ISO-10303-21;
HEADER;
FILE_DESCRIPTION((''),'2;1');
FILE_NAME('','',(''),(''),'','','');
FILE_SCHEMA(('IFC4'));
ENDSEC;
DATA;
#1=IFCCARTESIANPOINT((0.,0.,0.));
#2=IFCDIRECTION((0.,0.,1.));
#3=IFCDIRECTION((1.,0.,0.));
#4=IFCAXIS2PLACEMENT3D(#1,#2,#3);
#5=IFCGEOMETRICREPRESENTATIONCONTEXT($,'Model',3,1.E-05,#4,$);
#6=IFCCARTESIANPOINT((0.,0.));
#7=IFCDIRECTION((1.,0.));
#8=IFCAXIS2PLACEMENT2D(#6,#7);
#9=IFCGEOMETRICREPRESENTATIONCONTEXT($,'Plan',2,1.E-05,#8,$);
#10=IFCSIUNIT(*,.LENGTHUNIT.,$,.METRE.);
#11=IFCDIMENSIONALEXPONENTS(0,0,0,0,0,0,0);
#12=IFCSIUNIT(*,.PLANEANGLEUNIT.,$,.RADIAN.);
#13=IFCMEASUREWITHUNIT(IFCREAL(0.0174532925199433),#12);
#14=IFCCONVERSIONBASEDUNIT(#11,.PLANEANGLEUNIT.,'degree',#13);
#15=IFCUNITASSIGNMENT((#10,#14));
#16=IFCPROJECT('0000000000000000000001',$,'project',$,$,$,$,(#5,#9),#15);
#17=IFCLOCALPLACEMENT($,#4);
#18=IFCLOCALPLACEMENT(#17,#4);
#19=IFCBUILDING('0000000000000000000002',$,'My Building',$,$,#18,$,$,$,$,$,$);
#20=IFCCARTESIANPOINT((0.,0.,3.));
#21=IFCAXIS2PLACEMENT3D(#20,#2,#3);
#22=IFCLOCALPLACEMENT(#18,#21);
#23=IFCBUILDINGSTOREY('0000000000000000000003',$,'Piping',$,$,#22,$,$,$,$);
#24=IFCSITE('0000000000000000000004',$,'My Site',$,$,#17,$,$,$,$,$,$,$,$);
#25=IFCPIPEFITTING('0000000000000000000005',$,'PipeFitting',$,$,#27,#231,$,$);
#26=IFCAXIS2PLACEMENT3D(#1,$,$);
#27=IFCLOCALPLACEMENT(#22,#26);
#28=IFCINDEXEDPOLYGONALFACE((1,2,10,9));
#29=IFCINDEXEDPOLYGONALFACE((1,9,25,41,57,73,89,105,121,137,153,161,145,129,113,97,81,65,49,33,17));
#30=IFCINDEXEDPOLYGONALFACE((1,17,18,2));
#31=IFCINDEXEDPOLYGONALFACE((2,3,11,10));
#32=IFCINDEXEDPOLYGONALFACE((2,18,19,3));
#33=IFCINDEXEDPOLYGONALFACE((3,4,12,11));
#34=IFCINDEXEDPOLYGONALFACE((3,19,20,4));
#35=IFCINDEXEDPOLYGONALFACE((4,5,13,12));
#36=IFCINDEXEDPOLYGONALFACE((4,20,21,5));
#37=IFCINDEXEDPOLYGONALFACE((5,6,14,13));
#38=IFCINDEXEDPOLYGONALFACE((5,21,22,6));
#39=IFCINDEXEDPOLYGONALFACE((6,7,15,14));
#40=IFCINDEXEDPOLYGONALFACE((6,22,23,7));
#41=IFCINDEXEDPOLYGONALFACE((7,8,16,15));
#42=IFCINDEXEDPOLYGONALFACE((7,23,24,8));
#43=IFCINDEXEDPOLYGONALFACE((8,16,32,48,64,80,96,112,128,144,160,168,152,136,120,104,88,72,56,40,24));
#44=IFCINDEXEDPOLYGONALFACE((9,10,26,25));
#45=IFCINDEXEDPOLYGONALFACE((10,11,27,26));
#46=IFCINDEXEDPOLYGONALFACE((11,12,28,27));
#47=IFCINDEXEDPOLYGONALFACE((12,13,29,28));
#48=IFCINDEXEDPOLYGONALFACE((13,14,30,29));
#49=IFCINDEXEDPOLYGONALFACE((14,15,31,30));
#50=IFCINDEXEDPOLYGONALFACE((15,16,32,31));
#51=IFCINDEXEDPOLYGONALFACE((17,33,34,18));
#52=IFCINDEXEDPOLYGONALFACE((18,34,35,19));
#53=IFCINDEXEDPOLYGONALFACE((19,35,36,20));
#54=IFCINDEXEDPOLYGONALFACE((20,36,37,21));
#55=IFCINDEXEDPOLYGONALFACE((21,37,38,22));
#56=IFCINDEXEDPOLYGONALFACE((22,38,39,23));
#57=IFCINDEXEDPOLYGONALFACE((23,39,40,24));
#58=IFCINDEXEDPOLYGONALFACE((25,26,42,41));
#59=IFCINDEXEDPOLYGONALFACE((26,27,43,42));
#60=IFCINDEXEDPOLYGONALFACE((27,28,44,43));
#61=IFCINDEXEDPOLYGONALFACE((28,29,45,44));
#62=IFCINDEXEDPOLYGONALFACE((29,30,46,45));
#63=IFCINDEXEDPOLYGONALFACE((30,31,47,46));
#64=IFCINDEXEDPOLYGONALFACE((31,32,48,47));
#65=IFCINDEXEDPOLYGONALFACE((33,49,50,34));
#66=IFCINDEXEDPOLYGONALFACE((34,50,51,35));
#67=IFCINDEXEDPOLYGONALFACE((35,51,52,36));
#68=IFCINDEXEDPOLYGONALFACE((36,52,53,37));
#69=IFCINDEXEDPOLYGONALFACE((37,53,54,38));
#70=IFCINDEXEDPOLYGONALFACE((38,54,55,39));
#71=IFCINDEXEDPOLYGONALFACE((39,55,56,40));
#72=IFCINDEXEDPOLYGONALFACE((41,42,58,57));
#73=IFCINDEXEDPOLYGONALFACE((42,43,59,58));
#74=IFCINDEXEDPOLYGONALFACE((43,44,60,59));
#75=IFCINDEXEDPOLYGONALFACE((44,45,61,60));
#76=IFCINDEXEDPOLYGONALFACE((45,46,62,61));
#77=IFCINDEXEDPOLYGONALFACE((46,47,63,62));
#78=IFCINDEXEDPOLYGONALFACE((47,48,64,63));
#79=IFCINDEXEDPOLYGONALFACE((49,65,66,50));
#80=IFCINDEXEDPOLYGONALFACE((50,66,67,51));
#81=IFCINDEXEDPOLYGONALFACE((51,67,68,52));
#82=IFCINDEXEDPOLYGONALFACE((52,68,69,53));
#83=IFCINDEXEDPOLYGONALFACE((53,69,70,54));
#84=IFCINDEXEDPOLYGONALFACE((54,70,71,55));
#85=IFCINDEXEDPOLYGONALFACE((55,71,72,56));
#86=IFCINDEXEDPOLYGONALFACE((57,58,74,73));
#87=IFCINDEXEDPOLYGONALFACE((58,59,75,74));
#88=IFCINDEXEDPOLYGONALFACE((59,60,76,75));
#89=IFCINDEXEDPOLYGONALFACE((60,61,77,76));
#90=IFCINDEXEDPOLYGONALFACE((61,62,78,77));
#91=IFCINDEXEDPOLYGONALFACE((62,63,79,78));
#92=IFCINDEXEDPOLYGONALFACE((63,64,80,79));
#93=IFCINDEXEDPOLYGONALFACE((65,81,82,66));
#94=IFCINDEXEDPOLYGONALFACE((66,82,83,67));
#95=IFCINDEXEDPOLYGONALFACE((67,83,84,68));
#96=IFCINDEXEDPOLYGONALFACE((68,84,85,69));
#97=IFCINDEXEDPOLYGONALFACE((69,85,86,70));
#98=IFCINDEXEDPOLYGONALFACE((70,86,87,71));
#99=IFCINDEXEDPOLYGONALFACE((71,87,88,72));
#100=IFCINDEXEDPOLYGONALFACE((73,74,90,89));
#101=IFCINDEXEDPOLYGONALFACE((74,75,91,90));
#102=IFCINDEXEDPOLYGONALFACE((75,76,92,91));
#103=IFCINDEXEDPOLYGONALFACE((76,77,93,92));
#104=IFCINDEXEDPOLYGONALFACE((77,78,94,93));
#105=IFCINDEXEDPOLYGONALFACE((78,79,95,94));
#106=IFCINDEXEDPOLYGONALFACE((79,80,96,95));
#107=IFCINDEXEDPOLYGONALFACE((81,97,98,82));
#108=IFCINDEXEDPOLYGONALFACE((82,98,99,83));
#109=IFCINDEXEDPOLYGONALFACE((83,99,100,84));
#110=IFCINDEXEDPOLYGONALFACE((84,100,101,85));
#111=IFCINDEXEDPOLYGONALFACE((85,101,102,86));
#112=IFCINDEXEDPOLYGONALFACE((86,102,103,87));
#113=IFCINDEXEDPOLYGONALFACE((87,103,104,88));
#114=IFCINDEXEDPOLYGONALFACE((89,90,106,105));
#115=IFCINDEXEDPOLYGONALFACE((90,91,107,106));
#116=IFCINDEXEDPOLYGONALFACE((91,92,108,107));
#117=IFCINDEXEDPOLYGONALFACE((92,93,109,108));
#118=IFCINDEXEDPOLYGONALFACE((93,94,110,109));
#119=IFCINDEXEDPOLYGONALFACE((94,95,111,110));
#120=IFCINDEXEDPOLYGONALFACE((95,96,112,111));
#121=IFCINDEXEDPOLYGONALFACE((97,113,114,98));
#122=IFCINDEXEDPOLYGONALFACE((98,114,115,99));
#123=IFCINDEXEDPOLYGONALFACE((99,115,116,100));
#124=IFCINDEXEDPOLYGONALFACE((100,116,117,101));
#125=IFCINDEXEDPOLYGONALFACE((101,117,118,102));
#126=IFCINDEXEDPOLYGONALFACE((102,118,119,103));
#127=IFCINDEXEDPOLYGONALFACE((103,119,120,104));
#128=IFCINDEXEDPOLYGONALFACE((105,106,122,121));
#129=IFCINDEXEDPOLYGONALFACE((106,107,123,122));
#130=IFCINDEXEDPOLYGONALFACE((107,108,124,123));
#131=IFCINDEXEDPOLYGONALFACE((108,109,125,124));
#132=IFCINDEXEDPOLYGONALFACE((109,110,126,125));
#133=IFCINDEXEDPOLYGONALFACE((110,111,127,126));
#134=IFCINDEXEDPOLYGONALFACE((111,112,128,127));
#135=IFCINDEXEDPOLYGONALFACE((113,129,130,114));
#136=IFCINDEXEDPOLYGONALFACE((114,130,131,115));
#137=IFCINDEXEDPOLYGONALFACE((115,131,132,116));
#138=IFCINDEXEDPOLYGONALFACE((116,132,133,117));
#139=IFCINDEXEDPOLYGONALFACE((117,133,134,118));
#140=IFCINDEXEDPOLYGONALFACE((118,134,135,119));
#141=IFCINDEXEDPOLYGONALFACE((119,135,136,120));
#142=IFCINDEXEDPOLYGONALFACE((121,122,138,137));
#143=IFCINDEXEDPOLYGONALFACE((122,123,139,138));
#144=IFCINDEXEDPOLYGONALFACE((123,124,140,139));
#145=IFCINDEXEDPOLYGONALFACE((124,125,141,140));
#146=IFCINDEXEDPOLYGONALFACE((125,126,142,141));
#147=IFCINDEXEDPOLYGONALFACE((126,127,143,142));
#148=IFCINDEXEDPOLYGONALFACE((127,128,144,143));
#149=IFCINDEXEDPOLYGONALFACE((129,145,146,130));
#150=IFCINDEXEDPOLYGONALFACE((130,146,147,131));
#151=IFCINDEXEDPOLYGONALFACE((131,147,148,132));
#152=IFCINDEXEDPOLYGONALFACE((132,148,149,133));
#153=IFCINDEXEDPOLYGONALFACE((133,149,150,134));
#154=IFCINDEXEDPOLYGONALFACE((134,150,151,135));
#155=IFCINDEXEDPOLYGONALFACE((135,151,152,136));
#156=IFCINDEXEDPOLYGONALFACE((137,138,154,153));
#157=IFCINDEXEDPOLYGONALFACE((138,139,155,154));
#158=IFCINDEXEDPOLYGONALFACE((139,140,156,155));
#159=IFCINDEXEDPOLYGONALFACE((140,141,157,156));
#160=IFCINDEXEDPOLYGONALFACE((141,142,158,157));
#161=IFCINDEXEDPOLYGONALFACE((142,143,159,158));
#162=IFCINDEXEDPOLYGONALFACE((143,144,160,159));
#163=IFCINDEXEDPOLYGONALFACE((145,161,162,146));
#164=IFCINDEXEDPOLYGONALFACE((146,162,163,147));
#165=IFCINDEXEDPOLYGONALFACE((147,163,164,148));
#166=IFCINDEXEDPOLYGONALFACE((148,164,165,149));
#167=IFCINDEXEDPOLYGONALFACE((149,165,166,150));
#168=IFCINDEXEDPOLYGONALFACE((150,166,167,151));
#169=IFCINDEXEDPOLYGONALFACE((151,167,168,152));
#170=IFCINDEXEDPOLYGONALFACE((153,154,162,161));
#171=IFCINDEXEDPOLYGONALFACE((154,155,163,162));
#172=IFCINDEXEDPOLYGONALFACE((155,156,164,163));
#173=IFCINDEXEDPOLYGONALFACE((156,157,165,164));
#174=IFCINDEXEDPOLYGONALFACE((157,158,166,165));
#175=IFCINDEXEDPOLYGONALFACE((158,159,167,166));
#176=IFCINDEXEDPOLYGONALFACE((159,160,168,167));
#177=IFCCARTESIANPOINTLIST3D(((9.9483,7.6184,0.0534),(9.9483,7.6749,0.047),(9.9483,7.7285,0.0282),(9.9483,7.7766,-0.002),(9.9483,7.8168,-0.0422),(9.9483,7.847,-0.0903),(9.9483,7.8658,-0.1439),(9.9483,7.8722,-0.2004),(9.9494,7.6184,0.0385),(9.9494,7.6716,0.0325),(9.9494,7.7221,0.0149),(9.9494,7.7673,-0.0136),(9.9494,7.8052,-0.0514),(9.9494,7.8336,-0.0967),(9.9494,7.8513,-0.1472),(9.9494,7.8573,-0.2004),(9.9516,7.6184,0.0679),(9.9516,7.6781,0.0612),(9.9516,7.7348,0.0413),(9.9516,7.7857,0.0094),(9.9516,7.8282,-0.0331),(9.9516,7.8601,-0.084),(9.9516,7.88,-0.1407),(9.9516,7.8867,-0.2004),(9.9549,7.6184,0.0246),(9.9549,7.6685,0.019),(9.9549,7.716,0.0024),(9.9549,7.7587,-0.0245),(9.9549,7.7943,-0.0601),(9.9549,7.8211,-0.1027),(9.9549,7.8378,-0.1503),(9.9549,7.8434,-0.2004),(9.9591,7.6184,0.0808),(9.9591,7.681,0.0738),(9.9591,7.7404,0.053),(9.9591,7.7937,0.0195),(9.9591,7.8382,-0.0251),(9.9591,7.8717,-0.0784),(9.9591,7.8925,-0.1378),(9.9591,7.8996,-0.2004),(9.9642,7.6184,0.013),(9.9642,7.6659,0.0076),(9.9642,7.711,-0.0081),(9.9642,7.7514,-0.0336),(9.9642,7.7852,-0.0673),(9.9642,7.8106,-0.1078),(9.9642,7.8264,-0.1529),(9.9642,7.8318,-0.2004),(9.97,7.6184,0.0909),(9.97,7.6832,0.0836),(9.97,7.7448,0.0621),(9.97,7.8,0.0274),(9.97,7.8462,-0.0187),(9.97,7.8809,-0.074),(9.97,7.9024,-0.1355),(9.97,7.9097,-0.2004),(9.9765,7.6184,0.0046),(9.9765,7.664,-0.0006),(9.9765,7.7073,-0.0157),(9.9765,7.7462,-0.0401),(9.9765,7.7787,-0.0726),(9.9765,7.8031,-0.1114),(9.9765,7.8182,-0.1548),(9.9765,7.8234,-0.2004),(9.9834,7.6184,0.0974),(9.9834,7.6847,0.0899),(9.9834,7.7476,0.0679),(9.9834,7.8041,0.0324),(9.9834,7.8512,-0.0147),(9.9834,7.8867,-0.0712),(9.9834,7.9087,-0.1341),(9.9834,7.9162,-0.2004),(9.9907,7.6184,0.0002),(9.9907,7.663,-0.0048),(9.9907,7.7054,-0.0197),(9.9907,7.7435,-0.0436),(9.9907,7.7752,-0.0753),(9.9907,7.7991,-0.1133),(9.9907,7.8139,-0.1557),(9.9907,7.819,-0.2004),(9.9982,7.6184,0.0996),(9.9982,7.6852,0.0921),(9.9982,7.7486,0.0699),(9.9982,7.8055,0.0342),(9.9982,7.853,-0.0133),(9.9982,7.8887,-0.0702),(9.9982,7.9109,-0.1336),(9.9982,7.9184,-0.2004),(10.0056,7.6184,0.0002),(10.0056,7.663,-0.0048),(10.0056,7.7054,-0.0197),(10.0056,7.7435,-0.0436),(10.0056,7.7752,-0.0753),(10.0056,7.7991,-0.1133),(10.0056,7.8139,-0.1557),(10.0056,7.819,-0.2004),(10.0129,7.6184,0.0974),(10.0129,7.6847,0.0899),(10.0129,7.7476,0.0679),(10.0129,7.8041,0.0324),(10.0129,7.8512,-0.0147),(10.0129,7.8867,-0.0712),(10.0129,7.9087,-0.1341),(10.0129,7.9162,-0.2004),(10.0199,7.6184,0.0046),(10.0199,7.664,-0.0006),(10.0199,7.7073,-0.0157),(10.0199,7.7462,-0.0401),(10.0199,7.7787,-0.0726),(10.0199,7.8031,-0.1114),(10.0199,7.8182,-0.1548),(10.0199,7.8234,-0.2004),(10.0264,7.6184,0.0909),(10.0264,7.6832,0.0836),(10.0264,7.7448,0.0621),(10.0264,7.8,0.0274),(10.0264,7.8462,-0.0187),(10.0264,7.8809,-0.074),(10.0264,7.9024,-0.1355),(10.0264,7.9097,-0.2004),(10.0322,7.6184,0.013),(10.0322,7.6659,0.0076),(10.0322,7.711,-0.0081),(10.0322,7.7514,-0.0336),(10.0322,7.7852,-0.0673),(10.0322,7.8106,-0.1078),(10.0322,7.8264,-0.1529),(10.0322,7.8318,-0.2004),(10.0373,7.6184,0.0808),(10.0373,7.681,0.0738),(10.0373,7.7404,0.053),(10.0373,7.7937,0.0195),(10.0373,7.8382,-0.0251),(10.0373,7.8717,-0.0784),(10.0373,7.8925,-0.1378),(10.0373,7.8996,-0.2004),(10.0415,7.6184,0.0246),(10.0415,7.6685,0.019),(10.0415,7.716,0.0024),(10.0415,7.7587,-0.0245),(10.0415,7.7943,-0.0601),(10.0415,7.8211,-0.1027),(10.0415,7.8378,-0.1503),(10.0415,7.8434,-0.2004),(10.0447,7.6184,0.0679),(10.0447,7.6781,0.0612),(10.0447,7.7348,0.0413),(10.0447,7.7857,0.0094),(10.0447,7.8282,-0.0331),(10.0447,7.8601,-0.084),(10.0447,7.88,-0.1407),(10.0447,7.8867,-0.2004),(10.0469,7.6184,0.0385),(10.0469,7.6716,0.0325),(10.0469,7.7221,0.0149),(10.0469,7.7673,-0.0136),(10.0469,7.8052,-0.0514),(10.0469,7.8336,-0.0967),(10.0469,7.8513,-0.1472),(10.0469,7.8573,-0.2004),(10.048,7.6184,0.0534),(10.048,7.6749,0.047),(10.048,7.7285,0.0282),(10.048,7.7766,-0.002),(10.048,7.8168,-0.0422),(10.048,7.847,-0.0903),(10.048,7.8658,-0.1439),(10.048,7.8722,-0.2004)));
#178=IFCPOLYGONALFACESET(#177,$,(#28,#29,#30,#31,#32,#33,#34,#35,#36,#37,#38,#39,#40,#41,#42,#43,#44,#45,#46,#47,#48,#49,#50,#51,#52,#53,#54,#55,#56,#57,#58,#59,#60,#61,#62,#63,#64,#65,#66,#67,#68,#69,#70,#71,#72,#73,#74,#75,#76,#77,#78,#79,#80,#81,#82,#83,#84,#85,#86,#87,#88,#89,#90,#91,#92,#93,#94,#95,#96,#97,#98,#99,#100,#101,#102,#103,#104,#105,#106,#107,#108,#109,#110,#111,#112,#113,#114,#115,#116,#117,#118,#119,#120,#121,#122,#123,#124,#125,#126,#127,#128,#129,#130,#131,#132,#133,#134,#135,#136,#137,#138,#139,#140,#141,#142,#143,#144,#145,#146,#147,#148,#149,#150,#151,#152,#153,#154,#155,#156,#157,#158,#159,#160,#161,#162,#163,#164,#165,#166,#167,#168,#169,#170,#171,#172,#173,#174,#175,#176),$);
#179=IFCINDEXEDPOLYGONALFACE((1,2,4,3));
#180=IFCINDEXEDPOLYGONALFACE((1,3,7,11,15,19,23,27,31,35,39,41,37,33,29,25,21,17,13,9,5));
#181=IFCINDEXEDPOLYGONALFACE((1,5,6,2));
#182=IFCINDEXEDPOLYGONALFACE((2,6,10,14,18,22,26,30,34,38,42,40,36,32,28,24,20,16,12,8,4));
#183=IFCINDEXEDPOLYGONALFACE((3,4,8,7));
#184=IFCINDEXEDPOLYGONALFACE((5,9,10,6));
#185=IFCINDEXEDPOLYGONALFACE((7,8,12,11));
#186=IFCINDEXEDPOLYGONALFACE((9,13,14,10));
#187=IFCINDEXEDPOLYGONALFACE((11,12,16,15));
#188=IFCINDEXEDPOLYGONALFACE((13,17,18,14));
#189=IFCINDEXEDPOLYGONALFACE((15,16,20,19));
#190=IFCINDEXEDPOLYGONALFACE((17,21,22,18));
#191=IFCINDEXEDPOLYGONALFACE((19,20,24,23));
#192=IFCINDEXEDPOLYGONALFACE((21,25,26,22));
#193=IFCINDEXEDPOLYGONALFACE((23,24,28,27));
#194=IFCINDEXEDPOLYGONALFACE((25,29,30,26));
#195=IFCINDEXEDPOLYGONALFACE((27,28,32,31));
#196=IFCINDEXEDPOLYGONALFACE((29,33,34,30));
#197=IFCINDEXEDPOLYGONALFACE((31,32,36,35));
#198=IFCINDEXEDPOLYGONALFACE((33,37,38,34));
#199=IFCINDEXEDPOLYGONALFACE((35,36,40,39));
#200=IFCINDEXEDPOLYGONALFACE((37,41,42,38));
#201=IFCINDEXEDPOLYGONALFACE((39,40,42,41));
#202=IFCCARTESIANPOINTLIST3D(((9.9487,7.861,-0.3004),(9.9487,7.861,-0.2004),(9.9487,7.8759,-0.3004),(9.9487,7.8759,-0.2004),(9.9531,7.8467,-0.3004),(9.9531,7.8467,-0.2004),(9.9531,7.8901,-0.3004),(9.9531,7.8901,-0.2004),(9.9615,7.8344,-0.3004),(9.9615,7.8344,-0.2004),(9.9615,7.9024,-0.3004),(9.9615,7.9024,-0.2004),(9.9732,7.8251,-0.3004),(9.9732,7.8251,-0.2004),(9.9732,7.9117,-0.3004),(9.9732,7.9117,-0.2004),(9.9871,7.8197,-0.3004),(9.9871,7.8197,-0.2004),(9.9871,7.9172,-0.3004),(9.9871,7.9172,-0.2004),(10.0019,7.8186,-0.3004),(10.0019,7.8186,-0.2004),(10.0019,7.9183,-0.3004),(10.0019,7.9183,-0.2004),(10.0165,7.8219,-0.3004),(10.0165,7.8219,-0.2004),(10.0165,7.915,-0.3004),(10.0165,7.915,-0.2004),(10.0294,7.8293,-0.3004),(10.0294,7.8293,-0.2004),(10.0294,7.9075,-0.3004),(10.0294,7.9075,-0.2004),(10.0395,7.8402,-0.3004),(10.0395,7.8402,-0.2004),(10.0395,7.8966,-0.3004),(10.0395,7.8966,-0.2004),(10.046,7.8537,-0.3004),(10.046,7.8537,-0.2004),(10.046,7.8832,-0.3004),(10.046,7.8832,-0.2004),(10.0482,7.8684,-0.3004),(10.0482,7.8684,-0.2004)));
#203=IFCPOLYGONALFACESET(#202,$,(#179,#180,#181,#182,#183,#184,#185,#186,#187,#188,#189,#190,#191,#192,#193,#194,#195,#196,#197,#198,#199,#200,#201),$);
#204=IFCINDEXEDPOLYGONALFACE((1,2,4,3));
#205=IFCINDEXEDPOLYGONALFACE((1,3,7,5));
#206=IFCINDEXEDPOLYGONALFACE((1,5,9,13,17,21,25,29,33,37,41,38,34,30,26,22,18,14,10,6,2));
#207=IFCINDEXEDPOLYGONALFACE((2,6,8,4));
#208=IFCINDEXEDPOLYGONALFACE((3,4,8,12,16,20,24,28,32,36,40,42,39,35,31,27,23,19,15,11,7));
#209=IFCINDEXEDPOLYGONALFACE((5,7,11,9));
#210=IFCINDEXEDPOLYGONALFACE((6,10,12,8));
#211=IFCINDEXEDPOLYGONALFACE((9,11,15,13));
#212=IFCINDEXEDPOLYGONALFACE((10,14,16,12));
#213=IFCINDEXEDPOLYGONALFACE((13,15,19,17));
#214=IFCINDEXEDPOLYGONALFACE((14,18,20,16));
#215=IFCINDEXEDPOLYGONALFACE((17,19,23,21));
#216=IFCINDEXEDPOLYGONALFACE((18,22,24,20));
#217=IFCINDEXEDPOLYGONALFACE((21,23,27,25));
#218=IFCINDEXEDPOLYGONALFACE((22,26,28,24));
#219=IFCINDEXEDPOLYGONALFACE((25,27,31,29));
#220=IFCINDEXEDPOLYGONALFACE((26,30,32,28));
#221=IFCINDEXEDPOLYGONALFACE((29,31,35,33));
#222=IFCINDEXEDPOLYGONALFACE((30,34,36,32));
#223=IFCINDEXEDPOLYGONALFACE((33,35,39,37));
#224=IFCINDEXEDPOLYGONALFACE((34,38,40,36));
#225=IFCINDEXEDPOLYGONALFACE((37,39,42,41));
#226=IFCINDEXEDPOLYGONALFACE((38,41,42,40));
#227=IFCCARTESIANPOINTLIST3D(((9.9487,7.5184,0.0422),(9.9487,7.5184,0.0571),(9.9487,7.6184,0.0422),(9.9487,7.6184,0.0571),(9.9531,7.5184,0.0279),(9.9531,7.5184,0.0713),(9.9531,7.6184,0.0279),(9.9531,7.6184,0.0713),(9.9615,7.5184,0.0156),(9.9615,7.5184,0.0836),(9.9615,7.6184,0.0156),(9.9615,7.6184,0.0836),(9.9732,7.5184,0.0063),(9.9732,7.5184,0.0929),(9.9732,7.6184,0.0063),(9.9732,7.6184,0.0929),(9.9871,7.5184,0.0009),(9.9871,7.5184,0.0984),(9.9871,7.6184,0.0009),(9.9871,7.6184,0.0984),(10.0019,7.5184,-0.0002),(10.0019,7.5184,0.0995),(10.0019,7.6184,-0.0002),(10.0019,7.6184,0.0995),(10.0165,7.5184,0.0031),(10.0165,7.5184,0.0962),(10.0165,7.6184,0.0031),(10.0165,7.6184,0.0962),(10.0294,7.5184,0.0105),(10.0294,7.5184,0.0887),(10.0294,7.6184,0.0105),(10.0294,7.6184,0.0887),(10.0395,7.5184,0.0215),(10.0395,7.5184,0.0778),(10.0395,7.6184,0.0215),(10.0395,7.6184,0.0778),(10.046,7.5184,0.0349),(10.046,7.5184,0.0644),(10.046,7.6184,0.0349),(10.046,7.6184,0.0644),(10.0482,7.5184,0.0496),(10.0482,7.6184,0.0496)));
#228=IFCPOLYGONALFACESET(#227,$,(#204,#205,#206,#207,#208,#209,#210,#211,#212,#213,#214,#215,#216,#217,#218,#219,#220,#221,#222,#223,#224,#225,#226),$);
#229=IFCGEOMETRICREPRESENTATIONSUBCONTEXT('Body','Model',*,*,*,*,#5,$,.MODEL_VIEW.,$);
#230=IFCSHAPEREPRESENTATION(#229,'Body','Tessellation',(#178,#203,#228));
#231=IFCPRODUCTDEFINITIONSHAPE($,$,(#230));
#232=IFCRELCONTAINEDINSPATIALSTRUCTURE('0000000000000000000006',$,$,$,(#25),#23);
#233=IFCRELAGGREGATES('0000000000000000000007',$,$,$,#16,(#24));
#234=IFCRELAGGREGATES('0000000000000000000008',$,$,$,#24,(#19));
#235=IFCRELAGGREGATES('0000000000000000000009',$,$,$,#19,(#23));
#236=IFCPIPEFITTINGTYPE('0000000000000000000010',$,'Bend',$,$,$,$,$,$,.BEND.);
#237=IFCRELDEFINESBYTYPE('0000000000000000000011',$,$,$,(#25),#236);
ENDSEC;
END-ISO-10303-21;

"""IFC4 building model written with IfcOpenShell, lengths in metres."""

from ifc_helpers import new_model, entity, si_unit, converted_unit, frame, origin_with_axes, origin_2d_with_axis, place, context, subcontext, project, spatial, circle, extrude, source, transform, mapped, type_object, type_shapes, element, save


model = new_model("IFC4")

# Units and contexts
model_context = context("Model", 3, precision=1e-05, world=origin_with_axes())
plan_context = context("Plan", 2, precision=1e-05, world=origin_2d_with_axis())
body_context = subcontext(model_context, "Body", "Model", "MODEL_VIEW")
ifc_project = project(units=[si_unit("LENGTHUNIT", "METRE"), converted_unit("PLANEANGLEUNIT", "degree", entity("IfcReal", 0.0174532925199433), si_unit("PLANEANGLEUNIT", "RADIAN"), dimensions=[0, 0, 0, 0, 0, 0, 0])], contexts=[model_context, plan_context])

# Site, building, storey
site_placement = place(None, origin_with_axes())
site = spatial("IfcSite", under=ifc_project, at=site_placement, Name="My Site")
building_placement = place(site_placement, origin_with_axes())
building = spatial("IfcBuilding", under=site, at=building_placement, Name="My Building")
storey_placement = place(building_placement, frame((0.0, 0.0, 3.0), z_axis=(0.0, 0.0, 1.0), x_axis=(1.0, 0.0, 0.0)))
storey = spatial("IfcBuildingStorey", under=building, at=storey_placement, Name="Piping")

# Pipe fitting
pipe_fitting_type = type_object("IfcPipeFittingType", Name="Bend", PredefinedType="BEND")
shared_shape = source(origin_with_axes(), body_context, "Body", "SolidModel", [
    entity("IfcSweptDiskSolid", entity("IfcIndexedPolyCurve", entity("IfcCartesianPointList3D", [[0.0, 0.0, -0.1], [0.0, 0.0732, -0.2768], [0.0, 0.25, -0.35]]), [entity("IfcArcIndex", [1, 2, 3])]), 0.05),
    extrude(circle(Radius=0.05), origin_with_axes(), (0.0, 0.0, -1.0), 0.1),
    extrude(circle(Radius=0.05), frame((0.0, 0.25, -0.35), z_axis=(0.0, 1.0, 0.000007), x_axis=(1.0, 0.0, 0.0)), (0.0, 0.0, 1.0), 0.1),
])
type_shapes(pipe_fitting_type, [shared_shape])
for number, where, z_axis, x_axis, name in (
    (1, (9.9982, 7.8684, -0.3004), (0.0, 0.0, -1.0), (1.0, 0.0, 0.0), "PipeFitting"),
):
    element("IfcPipeFitting", number, at=place(storey_placement, frame(where, z_axis=z_axis, x_axis=x_axis)), inside=storey, type_object=pipe_fitting_type, Name=name, context=body_context, shape_type="MappedRepresentation", body=[
        mapped(shared_shape, transform((0.0, 0.0, 0.0), x_axis=(1.0, 0.0, 0.0), y_axis=(0.0, 1.0, 0.0), z_axis=(0.0, 0.0, 1.0), scale=1.0)),
    ])

save(model, "model.ifc")
